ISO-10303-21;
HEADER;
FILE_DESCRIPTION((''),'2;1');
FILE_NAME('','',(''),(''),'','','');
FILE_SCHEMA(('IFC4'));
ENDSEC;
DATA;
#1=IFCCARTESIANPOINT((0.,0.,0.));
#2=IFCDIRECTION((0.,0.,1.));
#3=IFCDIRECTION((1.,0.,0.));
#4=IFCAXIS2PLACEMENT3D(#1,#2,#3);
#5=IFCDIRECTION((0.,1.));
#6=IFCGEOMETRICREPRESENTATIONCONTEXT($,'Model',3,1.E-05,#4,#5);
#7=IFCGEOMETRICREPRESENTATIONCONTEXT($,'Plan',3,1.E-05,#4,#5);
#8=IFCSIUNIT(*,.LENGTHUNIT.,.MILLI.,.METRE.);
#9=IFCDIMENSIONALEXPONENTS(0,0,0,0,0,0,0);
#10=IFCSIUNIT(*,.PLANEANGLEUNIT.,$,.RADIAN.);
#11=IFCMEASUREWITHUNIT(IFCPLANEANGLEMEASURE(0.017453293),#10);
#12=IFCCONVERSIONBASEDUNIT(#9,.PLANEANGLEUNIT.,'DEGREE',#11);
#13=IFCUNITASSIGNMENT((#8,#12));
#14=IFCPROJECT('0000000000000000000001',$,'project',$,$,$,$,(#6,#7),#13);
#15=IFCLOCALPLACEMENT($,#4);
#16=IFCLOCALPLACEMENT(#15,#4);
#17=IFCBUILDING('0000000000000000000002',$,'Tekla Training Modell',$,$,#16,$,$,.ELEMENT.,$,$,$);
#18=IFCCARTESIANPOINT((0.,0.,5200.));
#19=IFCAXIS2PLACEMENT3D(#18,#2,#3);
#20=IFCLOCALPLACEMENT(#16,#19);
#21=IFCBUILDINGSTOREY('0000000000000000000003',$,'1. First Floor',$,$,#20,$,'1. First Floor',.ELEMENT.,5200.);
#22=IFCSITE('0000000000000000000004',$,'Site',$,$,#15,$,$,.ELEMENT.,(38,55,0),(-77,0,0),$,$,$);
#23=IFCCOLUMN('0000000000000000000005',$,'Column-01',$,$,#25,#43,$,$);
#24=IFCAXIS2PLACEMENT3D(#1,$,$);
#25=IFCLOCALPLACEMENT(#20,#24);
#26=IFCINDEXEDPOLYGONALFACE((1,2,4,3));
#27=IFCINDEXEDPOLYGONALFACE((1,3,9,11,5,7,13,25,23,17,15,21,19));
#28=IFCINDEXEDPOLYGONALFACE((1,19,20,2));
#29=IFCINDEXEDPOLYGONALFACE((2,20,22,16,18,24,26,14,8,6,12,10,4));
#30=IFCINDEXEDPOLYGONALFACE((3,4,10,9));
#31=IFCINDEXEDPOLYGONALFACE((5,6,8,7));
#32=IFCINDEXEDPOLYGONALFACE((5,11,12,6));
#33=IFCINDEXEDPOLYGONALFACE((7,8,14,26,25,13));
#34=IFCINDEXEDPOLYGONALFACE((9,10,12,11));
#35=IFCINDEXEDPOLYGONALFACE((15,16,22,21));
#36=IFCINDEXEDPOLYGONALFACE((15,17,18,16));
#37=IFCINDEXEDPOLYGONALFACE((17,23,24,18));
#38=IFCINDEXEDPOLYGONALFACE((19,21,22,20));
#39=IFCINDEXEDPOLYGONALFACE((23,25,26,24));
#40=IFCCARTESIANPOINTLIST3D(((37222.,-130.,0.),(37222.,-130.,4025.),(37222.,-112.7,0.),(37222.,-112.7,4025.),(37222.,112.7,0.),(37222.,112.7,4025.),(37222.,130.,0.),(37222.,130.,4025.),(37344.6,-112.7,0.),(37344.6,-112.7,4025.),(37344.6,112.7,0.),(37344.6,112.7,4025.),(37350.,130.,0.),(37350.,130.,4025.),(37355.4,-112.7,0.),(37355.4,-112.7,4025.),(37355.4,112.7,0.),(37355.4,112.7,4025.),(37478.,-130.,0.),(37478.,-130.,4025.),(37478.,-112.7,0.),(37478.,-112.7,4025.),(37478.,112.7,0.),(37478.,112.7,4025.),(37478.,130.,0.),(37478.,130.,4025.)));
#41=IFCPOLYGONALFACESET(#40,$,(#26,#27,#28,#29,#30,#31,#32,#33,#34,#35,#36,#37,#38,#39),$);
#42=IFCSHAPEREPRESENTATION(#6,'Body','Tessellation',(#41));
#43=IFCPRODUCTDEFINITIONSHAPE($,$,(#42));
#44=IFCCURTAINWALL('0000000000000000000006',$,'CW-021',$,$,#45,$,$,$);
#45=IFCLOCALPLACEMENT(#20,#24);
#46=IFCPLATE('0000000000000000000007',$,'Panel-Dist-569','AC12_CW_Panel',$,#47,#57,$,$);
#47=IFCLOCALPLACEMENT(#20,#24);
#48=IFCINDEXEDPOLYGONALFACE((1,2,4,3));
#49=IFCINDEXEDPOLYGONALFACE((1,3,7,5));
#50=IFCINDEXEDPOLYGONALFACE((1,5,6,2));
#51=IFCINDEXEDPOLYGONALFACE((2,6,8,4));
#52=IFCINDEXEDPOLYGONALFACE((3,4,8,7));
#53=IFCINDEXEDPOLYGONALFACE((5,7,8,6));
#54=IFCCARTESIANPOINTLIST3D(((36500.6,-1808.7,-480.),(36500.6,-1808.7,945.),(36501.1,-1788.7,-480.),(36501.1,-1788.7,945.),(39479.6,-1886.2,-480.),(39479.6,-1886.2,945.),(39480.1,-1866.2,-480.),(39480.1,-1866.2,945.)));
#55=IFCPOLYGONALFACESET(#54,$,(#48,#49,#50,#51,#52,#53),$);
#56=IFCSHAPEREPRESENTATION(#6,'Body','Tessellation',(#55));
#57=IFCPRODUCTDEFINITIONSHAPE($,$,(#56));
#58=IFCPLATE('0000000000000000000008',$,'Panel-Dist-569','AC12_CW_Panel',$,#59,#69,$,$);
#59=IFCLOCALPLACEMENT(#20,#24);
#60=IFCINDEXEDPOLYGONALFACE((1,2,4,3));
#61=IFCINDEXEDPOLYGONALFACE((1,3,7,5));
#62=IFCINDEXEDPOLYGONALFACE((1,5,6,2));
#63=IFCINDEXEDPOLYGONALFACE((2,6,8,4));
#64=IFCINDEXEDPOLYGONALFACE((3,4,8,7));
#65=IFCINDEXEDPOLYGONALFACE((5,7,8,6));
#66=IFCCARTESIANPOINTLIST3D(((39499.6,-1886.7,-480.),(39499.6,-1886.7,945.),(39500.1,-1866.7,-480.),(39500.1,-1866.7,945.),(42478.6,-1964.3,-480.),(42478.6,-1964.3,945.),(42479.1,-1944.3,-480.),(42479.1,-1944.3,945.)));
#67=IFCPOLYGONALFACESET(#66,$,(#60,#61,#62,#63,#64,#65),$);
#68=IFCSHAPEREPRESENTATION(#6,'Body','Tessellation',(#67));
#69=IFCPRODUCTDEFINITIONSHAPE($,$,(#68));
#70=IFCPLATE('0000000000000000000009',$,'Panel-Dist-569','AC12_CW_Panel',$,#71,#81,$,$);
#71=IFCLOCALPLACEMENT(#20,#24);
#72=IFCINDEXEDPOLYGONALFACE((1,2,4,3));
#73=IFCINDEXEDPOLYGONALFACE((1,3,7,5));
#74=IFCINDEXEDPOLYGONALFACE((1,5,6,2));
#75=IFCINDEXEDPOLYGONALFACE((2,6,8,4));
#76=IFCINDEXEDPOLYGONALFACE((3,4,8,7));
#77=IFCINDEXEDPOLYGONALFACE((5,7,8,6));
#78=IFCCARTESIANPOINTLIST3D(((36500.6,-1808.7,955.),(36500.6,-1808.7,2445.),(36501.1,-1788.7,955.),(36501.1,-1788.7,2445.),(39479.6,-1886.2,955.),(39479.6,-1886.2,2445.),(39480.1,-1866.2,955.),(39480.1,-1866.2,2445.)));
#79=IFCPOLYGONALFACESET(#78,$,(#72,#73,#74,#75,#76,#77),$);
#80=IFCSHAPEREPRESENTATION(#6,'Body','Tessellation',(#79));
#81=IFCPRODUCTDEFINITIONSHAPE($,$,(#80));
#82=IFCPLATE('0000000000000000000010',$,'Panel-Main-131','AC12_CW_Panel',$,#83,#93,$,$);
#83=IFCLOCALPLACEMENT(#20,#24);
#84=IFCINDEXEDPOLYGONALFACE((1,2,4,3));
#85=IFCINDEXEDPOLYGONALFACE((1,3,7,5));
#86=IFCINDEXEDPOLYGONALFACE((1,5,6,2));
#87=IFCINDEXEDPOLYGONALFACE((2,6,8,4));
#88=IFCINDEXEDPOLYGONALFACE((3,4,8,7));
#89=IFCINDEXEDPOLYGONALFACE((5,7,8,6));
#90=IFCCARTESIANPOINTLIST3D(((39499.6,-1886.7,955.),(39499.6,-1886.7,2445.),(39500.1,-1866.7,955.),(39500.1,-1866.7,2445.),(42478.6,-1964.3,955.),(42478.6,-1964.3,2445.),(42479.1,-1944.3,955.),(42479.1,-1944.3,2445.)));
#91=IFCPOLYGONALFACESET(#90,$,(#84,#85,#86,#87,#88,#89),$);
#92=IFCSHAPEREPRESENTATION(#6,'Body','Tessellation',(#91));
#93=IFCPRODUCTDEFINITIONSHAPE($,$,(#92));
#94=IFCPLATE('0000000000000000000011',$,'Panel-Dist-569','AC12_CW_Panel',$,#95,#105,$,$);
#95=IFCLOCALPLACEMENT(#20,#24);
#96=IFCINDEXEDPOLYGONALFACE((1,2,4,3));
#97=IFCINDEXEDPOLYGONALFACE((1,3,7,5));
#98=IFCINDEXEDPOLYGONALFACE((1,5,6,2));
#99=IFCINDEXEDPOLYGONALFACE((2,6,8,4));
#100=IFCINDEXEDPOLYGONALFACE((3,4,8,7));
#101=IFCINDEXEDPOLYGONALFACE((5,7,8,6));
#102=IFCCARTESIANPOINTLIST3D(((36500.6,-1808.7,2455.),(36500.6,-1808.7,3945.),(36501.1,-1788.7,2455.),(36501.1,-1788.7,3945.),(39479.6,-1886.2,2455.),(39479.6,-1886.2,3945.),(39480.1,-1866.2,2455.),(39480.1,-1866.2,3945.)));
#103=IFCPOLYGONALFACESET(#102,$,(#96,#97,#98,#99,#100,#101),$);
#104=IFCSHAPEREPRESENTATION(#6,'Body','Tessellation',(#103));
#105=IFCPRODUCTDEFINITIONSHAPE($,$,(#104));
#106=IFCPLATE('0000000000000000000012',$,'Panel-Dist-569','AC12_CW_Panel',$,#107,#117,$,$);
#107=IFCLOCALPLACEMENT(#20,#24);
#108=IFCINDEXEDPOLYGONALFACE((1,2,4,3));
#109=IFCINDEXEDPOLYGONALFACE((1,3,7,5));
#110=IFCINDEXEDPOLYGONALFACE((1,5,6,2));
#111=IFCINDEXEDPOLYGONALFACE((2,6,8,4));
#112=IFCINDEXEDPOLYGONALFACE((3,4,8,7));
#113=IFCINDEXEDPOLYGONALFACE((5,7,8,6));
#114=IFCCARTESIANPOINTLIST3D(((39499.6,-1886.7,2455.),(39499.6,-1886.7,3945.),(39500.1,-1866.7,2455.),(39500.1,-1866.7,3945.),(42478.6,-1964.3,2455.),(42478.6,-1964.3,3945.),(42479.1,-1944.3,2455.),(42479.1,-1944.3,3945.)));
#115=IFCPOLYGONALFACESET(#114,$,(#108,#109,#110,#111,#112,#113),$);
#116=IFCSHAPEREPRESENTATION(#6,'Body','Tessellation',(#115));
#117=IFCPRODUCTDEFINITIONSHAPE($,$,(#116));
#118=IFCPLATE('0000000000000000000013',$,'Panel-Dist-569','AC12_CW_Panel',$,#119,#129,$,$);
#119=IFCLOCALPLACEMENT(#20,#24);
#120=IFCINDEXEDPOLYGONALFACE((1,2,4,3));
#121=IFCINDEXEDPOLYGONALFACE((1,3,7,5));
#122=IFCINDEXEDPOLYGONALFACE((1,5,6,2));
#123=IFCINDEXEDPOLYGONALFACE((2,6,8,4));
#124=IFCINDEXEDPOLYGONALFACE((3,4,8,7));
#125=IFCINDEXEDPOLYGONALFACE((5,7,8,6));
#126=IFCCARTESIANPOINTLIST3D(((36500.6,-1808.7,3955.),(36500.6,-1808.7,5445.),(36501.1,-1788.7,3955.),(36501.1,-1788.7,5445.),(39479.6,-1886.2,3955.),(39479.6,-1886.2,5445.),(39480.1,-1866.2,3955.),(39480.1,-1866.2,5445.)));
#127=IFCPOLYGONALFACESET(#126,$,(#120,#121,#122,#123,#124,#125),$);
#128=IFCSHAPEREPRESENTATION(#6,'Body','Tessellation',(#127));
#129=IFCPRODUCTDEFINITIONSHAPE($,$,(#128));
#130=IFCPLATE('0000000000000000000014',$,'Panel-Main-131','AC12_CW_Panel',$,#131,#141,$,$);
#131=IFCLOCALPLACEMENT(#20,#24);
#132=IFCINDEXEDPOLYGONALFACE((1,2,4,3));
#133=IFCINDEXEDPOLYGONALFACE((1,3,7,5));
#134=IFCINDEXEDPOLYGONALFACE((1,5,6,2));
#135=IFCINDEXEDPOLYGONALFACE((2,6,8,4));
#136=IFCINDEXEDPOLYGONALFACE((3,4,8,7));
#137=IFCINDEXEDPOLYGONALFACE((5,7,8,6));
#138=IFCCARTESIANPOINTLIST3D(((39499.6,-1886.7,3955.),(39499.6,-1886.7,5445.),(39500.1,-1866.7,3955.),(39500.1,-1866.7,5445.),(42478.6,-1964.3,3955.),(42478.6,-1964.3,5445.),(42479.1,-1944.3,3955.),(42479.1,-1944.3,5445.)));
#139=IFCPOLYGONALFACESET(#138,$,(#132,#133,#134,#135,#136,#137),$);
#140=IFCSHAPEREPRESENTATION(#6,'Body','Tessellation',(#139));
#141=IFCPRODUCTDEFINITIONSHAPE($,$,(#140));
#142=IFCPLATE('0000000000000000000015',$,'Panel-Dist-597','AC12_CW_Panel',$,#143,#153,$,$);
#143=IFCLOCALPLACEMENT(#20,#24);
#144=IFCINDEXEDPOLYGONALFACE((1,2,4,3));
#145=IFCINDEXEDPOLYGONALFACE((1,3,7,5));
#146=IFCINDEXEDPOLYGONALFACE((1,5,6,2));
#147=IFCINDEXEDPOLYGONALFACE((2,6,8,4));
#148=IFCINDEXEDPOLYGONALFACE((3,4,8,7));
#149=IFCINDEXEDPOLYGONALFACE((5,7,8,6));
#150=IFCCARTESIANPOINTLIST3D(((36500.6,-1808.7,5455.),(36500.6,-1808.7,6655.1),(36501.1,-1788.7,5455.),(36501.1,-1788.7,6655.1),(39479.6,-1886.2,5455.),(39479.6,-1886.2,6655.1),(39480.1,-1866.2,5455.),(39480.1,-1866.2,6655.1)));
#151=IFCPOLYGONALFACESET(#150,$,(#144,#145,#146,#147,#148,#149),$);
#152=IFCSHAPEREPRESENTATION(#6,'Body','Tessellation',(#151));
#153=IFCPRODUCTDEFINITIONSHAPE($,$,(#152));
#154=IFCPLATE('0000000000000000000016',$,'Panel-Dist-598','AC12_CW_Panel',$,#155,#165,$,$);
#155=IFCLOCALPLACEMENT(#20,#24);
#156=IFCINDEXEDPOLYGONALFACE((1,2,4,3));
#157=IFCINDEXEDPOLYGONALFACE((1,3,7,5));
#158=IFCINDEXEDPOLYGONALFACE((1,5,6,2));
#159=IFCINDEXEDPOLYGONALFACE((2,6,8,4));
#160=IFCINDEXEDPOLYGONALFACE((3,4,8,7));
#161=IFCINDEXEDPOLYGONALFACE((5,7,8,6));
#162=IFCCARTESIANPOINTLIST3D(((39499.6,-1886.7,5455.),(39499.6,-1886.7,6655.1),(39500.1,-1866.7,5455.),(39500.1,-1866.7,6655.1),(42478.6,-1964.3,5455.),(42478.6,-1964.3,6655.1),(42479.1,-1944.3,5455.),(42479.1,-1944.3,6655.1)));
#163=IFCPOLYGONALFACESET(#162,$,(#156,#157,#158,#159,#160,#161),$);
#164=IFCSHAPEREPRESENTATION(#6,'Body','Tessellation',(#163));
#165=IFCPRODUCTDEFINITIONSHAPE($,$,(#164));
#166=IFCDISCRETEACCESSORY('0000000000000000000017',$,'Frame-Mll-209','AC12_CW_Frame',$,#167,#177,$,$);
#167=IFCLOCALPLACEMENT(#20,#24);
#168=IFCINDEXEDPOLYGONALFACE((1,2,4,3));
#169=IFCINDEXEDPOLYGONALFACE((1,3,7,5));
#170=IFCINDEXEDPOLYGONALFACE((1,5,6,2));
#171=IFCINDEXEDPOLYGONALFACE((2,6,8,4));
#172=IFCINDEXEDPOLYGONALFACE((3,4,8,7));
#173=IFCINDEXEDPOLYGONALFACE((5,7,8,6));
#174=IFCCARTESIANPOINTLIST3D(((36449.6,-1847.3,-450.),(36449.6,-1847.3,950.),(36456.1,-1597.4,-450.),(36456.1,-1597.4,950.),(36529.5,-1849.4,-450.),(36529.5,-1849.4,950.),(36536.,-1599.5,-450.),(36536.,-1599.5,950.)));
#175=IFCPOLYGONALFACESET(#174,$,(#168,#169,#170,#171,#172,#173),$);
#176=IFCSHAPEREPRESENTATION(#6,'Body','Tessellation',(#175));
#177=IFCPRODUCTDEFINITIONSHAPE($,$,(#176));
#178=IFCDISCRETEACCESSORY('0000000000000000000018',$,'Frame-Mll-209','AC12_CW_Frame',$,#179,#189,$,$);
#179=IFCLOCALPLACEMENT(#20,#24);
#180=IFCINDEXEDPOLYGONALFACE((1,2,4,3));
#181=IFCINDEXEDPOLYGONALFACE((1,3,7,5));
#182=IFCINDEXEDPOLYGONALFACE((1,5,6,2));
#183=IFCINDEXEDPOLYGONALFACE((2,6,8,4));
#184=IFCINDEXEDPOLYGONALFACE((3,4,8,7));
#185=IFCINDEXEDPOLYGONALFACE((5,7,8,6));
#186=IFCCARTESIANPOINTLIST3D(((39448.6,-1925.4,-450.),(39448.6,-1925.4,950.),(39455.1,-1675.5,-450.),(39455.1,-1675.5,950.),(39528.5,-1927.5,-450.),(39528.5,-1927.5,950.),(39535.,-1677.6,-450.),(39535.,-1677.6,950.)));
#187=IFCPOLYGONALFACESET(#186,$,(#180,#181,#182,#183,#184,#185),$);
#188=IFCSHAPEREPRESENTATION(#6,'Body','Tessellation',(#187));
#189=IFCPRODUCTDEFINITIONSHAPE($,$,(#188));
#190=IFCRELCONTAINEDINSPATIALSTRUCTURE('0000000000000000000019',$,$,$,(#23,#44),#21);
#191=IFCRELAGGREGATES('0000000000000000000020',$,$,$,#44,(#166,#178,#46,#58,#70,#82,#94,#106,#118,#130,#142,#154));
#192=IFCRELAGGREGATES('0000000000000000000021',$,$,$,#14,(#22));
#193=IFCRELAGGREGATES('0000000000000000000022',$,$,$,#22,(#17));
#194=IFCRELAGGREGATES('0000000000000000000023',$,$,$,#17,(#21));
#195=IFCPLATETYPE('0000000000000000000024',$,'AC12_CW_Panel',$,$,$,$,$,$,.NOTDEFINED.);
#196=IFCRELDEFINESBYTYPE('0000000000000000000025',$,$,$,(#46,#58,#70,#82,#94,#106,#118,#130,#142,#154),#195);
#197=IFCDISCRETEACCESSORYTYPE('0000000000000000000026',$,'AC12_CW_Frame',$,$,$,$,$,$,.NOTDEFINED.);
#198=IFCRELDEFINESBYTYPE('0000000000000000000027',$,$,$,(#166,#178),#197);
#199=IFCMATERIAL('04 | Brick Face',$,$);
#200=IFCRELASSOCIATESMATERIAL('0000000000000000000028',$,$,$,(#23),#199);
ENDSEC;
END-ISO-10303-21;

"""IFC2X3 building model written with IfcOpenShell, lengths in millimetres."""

from ifc_helpers import new_model, entity, si_unit, converted_unit, direction, frame, origin_with_axes, place, context, project, spatial, polyline, outline, extrude, source, transform, mapped, material, type_object, element, aggregate, save


model = new_model("IFC2X3")

# Units and contexts
model_context = context("Model", 3, precision=1e-05, world=origin_with_axes(), true_north=direction((0.0, 1.0)))
plan_context = context("Plan", 3, precision=1e-05, world=origin_with_axes(), true_north=direction((0.0, 1.0)))
ifc_project = project(units=[si_unit("LENGTHUNIT", "METRE", prefix="MILLI"), converted_unit("PLANEANGLEUNIT", "DEGREE", entity("IfcPlaneAngleMeasure", 0.017453293), si_unit("PLANEANGLEUNIT", "RADIAN"), dimensions=[0, 0, 0, 0, 0, 0, 0])], contexts=[model_context, plan_context])

# Site, building, storey
site_placement = place(None, origin_with_axes())
site = spatial("IfcSite", under=ifc_project, at=site_placement, Name="Site", CompositionType="ELEMENT", RefLatitude=(38, 55, 0), RefLongitude=(-77, 0, 0))
building_placement = place(site_placement, origin_with_axes())
building = spatial("IfcBuilding", under=site, at=building_placement, Name="Tekla Training Modell", CompositionType="ELEMENT")
storey_placement = place(building_placement, frame((0.0, 0.0, 5200.0), z_axis=(0.0, 0.0, 1.0), x_axis=(1.0, 0.0, 0.0)))
storey = spatial("IfcBuildingStorey", under=building, at=storey_placement, Name="1. First Floor", LongName="1. First Floor", CompositionType="ELEMENT", Elevation=5200.0)

# Column
ifc_material = material(Name="04 | Brick Face")
column_placement = place(storey_placement, frame((37350.0, 0.0, 0.0), z_axis=(0.0, 0.0, 1.0), x_axis=(1.0, 0.0, 0.0)))
element("IfcColumn", 1, at=column_placement, inside=storey, material=ifc_material, Name="Column-01", context=model_context, shape_type="SweptSolid", body=[
    extrude(outline(polyline([(0.0, 130.0), (-128.0, 130.0), (-128.0, 112.7), (-5.3, 112.7), (-5.3, -112.7), (-128.0, -112.7), (-128.0, -130.0), (128.0, -130.0), (128.0, -112.7), (5.3, -112.7), (5.3, 112.7), (128.0, 112.7), (128.0, 130.0), (0.0, 130.0)])), origin_with_axes(), (0.0, 0.0, 1.0), 4025.0),
])

# Curtain wall, plates, discrete accessories
curtain_wall_placement = place(storey_placement, frame((9500.0, -1095.8, -550.0), z_axis=(0.0, 0.0, 1.0), x_axis=(0.999661, -0.026022, 0.0)))
curtain_wall = element("IfcCurtainWall", 2, at=curtain_wall_placement, inside=storey, Name="CW-021")
plate_type = type_object("IfcPlateType", Name="AC12_CW_Panel", PredefinedType="NOTDEFINED")
shared_shape_1 = source(origin_with_axes(), model_context, "Body", "SweptSolid", [
    extrude(outline(polyline([(0.0, 0.0), (2980.0, 0.0), (2980.0, -20.0), (0.0, -20.0), (0.0, 0.0)])), origin_with_axes(), (0.0, 0.0, 1.0), 1425.0),
])
plate_1_placement = place(storey_placement, frame((36501.1, -1788.7, -480.0), z_axis=(0.0, 0.0, 1.0), x_axis=(0.999661, -0.026022, 0.0)))
plate_1 = element("IfcPlate", 3, at=plate_1_placement, type_object=plate_type, Name="Panel-Dist-569", Description="AC12_CW_Panel", context=model_context, shape_type="MappedRepresentation", body=[
    mapped(shared_shape_1, transform((0.0, 0.0, 0.0), scale=1.0)),
])
plate_2_placement = place(storey_placement, frame((39500.1, -1866.7, -480.0), z_axis=(0.0, 0.0, 1.0), x_axis=(0.999661, -0.026022, 0.0)))
plate_2 = element("IfcPlate", 4, at=plate_2_placement, type_object=plate_type, Name="Panel-Dist-569", Description="AC12_CW_Panel", context=model_context, shape_type="MappedRepresentation", body=[
    mapped(shared_shape_1, transform((0.0, 0.0, 0.0), scale=1.0)),
])
shared_shape_2 = source(origin_with_axes(), model_context, "Body", "SweptSolid", [
    extrude(outline(polyline([(0.0, 0.0), (2980.0, 0.0), (2980.0, -20.0), (0.0, -20.0), (0.0, 0.0)])), origin_with_axes(), (0.0, 0.0, 1.0), 1490.0),
])
plate_3_placement = place(storey_placement, frame((36501.1, -1788.7, 955.0), z_axis=(0.0, 0.0, 1.0), x_axis=(0.999661, -0.026022, 0.0)))
plate_3 = element("IfcPlate", 5, at=plate_3_placement, type_object=plate_type, Name="Panel-Dist-569", Description="AC12_CW_Panel", context=model_context, shape_type="MappedRepresentation", body=[
    mapped(shared_shape_2, transform((0.0, 0.0, 0.0), scale=1.0)),
])
plate_4_placement = place(storey_placement, frame((39500.1, -1866.7, 955.0), z_axis=(0.0, 0.0, 1.0), x_axis=(0.999661, -0.026022, 0.0)))
plate_4 = element("IfcPlate", 6, at=plate_4_placement, type_object=plate_type, Name="Panel-Main-131", Description="AC12_CW_Panel", context=model_context, shape_type="MappedRepresentation", body=[
    mapped(shared_shape_2, transform((0.0, 0.0, 0.0), scale=1.0)),
])
plate_5_placement = place(storey_placement, frame((36501.1, -1788.7, 2455.0), z_axis=(0.0, 0.0, 1.0), x_axis=(0.999661, -0.026022, 0.0)))
plate_5 = element("IfcPlate", 7, at=plate_5_placement, type_object=plate_type, Name="Panel-Dist-569", Description="AC12_CW_Panel", context=model_context, shape_type="MappedRepresentation", body=[
    mapped(shared_shape_2, transform((0.0, 0.0, 0.0), scale=1.0)),
])
plate_6_placement = place(storey_placement, frame((39500.1, -1866.7, 2455.0), z_axis=(0.0, 0.0, 1.0), x_axis=(0.999661, -0.026022, 0.0)))
plate_6 = element("IfcPlate", 8, at=plate_6_placement, type_object=plate_type, Name="Panel-Dist-569", Description="AC12_CW_Panel", context=model_context, shape_type="MappedRepresentation", body=[
    mapped(shared_shape_2, transform((0.0, 0.0, 0.0), scale=1.0)),
])
plate_7_placement = place(storey_placement, frame((36501.1, -1788.7, 3955.0), z_axis=(0.0, 0.0, 1.0), x_axis=(0.999661, -0.026022, 0.0)))
plate_7 = element("IfcPlate", 9, at=plate_7_placement, type_object=plate_type, Name="Panel-Dist-569", Description="AC12_CW_Panel", context=model_context, shape_type="MappedRepresentation", body=[
    mapped(shared_shape_2, transform((0.0, 0.0, 0.0), scale=1.0)),
])
plate_8_placement = place(storey_placement, frame((39500.1, -1866.7, 3955.0), z_axis=(0.0, 0.0, 1.0), x_axis=(0.999661, -0.026022, 0.0)))
plate_8 = element("IfcPlate", 10, at=plate_8_placement, type_object=plate_type, Name="Panel-Main-131", Description="AC12_CW_Panel", context=model_context, shape_type="MappedRepresentation", body=[
    mapped(shared_shape_2, transform((0.0, 0.0, 0.0), scale=1.0)),
])
shared_shape_3 = source(origin_with_axes(), model_context, "Body", "SweptSolid", [
    extrude(outline(polyline([(0.0, 0.0), (2980.0, 0.0), (2980.0, -20.0), (0.0, -20.0), (0.0, 0.0)])), origin_with_axes(), (0.0, 0.0, 1.0), 1200.1),
])
plate_9_placement = place(storey_placement, frame((36501.1, -1788.7, 5455.0), z_axis=(0.0, 0.0, 1.0), x_axis=(0.999661, -0.026022, 0.0)))
plate_9 = element("IfcPlate", 11, at=plate_9_placement, type_object=plate_type, Name="Panel-Dist-597", Description="AC12_CW_Panel", context=model_context, shape_type="MappedRepresentation", body=[
    mapped(shared_shape_3, transform((0.0, 0.0, 0.0), scale=1.0)),
])
plate_10_placement = place(storey_placement, frame((39500.1, -1866.7, 5455.0), z_axis=(0.0, 0.0, 1.0), x_axis=(0.999661, -0.026022, 0.0)))
plate_10 = element("IfcPlate", 12, at=plate_10_placement, type_object=plate_type, Name="Panel-Dist-598", Description="AC12_CW_Panel", context=model_context, shape_type="MappedRepresentation", body=[
    mapped(shared_shape_3, transform((0.0, 0.0, 0.0), scale=1.0)),
])
discrete_accessory_type = type_object("IfcDiscreteAccessoryType", Name="AC12_CW_Frame")
shared_shape_4 = source(origin_with_axes(), model_context, "Body", "SweptSolid", [
    extrude(outline(polyline([(0.0, 0.0), (250.0, 0.0), (250.0, -1400.0), (0.0, -1400.0), (0.0, 0.0)])), origin_with_axes(), (0.0, 0.0, 1.0), 80.0),
])
discrete_accessory_1_placement = place(storey_placement, frame((36456.1, -1597.4, -450.0), z_axis=(0.999661, -0.026022, 0.0), x_axis=(-0.026022, -0.999661, 0.0)))
discrete_accessory_1 = element("IfcDiscreteAccessory", 13, at=discrete_accessory_1_placement, type_object=discrete_accessory_type, Name="Frame-Mll-209", Description="AC12_CW_Frame", context=model_context, shape_type="MappedRepresentation", body=[
    mapped(shared_shape_4, transform((0.0, 0.0, 0.0), scale=1.0)),
])
discrete_accessory_2_placement = place(storey_placement, frame((39455.1, -1675.5, -450.0), z_axis=(0.999661, -0.026022, 0.0), x_axis=(-0.026022, -0.999661, 0.0)))
discrete_accessory_2 = element("IfcDiscreteAccessory", 14, at=discrete_accessory_2_placement, type_object=discrete_accessory_type, Name="Frame-Mll-209", Description="AC12_CW_Frame", context=model_context, shape_type="MappedRepresentation", body=[
    mapped(shared_shape_4, transform((0.0, 0.0, 0.0), scale=1.0)),
])
aggregate(curtain_wall, [discrete_accessory_1, discrete_accessory_2, plate_1, plate_2, plate_3, plate_4, plate_5, plate_6, plate_7, plate_8, plate_9, plate_10])

save(model, "model.ifc")
